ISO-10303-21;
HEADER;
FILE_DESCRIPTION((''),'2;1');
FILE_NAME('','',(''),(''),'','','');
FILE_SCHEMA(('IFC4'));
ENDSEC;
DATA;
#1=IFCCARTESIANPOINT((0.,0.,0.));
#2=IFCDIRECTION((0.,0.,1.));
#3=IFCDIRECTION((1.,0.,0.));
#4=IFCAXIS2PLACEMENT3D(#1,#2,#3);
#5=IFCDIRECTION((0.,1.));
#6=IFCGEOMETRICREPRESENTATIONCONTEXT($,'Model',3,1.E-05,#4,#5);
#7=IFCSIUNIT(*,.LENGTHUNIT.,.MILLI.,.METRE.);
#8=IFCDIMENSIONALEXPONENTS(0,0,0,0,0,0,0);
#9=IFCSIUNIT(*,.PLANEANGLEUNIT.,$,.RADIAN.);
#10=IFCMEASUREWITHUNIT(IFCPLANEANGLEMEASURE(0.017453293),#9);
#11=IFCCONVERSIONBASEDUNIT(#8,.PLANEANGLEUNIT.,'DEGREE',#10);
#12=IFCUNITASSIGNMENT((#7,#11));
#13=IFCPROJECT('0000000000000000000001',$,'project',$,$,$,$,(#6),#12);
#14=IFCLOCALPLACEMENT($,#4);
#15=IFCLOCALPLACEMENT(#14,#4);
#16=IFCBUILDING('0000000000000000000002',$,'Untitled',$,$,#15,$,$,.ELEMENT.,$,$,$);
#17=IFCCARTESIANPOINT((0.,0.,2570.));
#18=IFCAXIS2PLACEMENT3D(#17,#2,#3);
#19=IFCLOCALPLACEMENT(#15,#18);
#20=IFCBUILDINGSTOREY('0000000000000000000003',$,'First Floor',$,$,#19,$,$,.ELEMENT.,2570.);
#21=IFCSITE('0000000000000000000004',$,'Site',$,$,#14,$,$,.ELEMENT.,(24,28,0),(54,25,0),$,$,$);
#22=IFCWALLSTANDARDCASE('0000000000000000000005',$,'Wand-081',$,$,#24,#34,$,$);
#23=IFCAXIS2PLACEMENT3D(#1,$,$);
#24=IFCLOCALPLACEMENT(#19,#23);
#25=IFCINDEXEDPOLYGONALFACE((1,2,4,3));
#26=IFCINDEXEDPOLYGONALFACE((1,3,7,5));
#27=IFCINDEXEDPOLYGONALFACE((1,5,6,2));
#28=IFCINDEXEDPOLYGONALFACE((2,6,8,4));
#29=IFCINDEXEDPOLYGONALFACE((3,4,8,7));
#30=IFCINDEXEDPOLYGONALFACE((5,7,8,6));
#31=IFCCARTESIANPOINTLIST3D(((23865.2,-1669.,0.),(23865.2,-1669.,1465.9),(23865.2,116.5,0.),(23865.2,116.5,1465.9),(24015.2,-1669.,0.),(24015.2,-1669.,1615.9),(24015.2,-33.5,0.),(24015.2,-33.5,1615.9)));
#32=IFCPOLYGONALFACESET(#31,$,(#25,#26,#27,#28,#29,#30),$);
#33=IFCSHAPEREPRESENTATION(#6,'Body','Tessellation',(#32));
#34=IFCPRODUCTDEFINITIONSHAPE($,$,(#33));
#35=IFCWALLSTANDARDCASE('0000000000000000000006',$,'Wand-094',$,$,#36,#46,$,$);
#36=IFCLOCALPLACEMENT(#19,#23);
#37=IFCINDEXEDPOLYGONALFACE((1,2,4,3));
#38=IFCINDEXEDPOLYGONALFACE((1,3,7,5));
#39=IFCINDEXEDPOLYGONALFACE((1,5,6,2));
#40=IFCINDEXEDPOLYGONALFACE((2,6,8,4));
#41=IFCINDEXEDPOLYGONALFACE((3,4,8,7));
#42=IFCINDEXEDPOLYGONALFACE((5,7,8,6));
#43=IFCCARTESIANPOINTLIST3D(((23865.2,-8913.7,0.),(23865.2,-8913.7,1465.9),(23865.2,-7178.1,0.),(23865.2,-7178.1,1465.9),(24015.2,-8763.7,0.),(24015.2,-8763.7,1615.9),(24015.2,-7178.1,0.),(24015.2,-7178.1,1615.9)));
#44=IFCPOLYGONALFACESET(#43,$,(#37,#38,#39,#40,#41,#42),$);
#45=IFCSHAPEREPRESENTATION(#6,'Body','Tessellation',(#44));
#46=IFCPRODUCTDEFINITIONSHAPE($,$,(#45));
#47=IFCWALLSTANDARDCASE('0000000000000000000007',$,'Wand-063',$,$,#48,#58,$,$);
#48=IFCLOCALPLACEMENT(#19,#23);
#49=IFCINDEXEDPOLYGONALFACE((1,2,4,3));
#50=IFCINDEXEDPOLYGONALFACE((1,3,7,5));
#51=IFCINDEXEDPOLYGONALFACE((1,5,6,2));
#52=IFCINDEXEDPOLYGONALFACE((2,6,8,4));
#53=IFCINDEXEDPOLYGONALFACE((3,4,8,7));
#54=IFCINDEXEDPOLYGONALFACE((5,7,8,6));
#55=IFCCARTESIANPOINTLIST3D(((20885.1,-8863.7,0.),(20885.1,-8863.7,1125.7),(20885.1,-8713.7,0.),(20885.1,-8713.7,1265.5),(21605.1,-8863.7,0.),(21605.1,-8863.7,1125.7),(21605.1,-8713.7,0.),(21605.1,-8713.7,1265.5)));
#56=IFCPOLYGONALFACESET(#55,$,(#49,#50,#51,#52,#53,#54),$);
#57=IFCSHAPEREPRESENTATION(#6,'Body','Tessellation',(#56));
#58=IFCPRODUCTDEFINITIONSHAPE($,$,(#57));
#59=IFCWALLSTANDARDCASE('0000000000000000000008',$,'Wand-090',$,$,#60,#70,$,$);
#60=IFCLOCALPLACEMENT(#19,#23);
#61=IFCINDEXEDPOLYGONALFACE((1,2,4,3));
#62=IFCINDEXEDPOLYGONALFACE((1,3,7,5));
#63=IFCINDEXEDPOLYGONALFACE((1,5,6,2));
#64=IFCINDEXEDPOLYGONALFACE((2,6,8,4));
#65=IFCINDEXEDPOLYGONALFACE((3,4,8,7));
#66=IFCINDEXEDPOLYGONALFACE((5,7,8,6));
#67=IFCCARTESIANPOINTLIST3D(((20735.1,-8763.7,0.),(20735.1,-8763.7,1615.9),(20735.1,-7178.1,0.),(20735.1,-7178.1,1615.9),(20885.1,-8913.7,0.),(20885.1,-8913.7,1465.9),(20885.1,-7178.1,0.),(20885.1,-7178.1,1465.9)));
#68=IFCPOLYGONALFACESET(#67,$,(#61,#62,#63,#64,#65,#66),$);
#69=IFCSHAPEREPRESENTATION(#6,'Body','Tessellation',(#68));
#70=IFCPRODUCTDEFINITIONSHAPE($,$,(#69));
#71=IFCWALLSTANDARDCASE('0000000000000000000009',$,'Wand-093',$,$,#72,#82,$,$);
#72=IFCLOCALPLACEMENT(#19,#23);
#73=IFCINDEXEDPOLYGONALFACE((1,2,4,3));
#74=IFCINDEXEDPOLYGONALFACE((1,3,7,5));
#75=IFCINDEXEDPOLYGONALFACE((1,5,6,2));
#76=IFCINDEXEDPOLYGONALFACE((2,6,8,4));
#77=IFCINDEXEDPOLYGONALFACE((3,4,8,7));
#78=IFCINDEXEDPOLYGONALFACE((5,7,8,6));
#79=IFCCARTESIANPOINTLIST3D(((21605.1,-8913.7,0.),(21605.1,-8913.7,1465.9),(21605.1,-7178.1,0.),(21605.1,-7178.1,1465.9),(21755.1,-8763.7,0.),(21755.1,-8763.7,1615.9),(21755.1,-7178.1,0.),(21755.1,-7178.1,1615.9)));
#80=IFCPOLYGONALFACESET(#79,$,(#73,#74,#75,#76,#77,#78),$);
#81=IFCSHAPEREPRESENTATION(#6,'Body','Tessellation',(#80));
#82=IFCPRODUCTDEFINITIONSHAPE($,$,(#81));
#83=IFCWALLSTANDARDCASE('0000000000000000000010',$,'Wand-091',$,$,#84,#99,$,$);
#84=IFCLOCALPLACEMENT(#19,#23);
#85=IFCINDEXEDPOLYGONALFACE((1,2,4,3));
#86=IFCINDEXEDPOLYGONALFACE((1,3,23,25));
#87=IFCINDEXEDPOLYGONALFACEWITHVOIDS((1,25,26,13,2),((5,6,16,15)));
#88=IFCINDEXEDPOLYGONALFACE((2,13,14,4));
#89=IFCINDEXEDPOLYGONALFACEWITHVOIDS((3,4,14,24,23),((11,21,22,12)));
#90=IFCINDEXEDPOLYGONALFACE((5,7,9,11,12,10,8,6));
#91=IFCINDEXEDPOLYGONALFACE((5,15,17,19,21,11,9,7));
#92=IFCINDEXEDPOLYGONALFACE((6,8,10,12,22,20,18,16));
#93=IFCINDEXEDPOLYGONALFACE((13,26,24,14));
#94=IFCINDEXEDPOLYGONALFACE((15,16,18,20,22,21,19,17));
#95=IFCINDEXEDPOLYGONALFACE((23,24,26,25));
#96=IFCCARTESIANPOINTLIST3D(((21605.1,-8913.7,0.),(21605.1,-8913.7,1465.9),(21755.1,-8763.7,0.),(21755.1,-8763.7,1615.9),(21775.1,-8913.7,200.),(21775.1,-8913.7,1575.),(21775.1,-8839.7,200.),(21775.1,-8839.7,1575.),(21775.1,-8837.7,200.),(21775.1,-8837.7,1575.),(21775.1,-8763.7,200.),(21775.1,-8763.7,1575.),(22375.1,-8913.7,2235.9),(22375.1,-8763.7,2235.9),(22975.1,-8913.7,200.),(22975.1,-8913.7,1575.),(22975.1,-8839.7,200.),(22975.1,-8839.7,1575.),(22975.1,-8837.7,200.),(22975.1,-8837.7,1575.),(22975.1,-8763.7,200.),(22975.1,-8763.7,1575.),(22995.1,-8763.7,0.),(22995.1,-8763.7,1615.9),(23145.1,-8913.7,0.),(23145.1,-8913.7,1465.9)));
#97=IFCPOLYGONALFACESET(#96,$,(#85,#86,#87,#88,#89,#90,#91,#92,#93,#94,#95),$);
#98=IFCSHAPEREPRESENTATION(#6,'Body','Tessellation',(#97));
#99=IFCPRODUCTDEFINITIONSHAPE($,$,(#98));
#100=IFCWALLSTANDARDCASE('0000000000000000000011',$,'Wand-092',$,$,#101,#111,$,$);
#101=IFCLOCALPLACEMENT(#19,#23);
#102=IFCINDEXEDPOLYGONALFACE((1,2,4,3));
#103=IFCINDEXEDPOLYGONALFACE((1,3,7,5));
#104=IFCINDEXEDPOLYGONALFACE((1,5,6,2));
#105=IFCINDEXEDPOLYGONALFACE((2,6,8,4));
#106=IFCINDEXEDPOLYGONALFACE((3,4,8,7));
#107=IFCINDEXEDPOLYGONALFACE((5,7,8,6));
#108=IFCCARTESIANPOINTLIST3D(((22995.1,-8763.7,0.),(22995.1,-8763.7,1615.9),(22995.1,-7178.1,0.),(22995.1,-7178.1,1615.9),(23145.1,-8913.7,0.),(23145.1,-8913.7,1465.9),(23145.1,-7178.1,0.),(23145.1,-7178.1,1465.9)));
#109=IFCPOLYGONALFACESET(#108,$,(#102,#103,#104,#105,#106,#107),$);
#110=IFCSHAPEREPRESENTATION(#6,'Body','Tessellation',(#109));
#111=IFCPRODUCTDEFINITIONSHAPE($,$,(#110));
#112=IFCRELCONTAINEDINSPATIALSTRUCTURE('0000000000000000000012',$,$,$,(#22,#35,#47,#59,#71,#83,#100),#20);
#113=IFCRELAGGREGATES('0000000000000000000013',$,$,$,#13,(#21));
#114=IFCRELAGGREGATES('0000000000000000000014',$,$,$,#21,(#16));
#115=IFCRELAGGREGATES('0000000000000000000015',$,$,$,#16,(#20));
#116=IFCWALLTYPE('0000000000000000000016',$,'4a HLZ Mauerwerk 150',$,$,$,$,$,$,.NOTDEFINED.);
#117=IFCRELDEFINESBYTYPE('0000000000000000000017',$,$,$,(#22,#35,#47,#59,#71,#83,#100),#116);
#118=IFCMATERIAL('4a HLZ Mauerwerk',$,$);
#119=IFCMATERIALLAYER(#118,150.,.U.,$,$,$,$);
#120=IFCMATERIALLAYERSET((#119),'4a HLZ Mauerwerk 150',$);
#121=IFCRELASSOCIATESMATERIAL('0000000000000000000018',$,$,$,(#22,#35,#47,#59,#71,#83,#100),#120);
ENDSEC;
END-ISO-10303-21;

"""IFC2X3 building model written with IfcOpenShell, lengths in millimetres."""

from ifc_helpers import new_model, entity, si_unit, converted_unit, direction, frame, origin_with_axes, origin_2d_with_axis, place, context, project, spatial, polyline, rectangle, outline, extrude, clip, halfspace, bounded_halfspace, material, layer, layer_set, layer_usage, type_object, element, save


model = new_model("IFC2X3")

# Units and contexts
model_context = context("Model", 3, precision=1e-05, world=origin_with_axes(), true_north=direction((0.0, 1.0)))
ifc_project = project(units=[si_unit("LENGTHUNIT", "METRE", prefix="MILLI"), converted_unit("PLANEANGLEUNIT", "DEGREE", entity("IfcPlaneAngleMeasure", 0.017453293), si_unit("PLANEANGLEUNIT", "RADIAN"), dimensions=[0, 0, 0, 0, 0, 0, 0])], contexts=[model_context])

# Site, building, storey
site_placement = place(None, origin_with_axes())
site = spatial("IfcSite", under=ifc_project, at=site_placement, Name="Site", CompositionType="ELEMENT", RefLatitude=(24, 28, 0), RefLongitude=(54, 25, 0))
building_placement = place(site_placement, origin_with_axes())
building = spatial("IfcBuilding", under=site, at=building_placement, Name="Untitled", CompositionType="ELEMENT")
storey_placement = place(building_placement, frame((0.0, 0.0, 2570.0), z_axis=(0.0, 0.0, 1.0), x_axis=(1.0, 0.0, 0.0)))
storey = spatial("IfcBuildingStorey", under=building, at=storey_placement, Name="First Floor", CompositionType="ELEMENT", Elevation=2570.0)

# Shared definitions
ifc_material = material(Name="4a HLZ Mauerwerk")
ifc_layer_1 = layer(ifc_material, 150.0, ventilated="UNKNOWN")
ifc_layer_set_1 = layer_set([ifc_layer_1], Name="4a HLZ Mauerwerk 150")
wall_type_1 = type_object("IfcWallType", Name="4a HLZ Mauerwerk 150", PredefinedType="NOTDEFINED")

# Walls
ifc_layer_usage_1 = layer_usage(ifc_layer_set_1, "AXIS2", "POSITIVE", 0.0)
wall_1_placement = place(storey_placement, frame((23865.2, 116.5, 0.0), z_axis=(0.0, 0.0, 1.0), x_axis=(0.0, -1.0, 0.0)))
element("IfcWallStandardCase", 1, at=wall_1_placement, inside=storey, type_object=wall_type_1, material=ifc_layer_usage_1, Name="Wand-081", context=model_context, shape_type="Clipping", body=[
    clip(extrude(outline(polyline([(0.0, 0.0), (1785.6, 0.0), (1785.6, 150.0), (150.0, 150.0), (0.0, 0.0)])), origin_with_axes(), (0.0, 0.0, 1.0), 5316.0), halfspace(frame((0.0, -733.0, 733.0), z_axis=(0.0, 0.707107, -0.707107), x_axis=(0.0, -0.707107, -0.707107)), True)),
])
ifc_layer_usage_2 = layer_usage(ifc_layer_set_1, "AXIS2", "NEGATIVE", 0.0)
wall_2_placement = place(storey_placement, frame((23865.2, -8913.7, 0.0), z_axis=(0.0, 0.0, 1.0), x_axis=(0.0, 1.0, 0.0)))
element("IfcWallStandardCase", 2, at=wall_2_placement, inside=storey, type_object=wall_type_1, material=ifc_layer_usage_2, Name="Wand-094", context=model_context, shape_type="Clipping", body=[
    clip(extrude(outline(polyline([(150.0, -150.0), (1735.6, -150.0), (1735.6, 0.0), (0.0, 0.0), (150.0, -150.0)])), origin_with_axes(), (0.0, 0.0, 1.0), 5316.0), halfspace(frame((0.0, 733.0, 733.0), z_axis=(0.0, -0.707107, -0.707107), x_axis=(0.0, -0.707107, 0.707107)), True)),
])
ifc_layer_usage_3 = layer_usage(ifc_layer_set_1, "AXIS2", "POSITIVE", 0.0)
wall_3_placement = place(storey_placement, frame((20885.1, -8863.7, 0.0), z_axis=(0.0, 0.0, 1.0), x_axis=(1.0, 0.0, 0.0)))
element("IfcWallStandardCase", 3, at=wall_3_placement, inside=storey, type_object=wall_type_1, material=ifc_layer_usage_3, Name="Wand-063", context=model_context, shape_type="Clipping", body=[
    clip(extrude(outline(polyline([(0.0, 0.0), (720.0, 0.0), (720.0, 150.0), (0.0, 150.0), (0.0, 0.0)])), origin_with_axes(), (0.0, 0.0, 1.0), 5316.0), bounded_halfspace(frame((0.0, -561.5, 602.1), z_axis=(0.0, 0.681998, -0.731354), x_axis=(0.0, -0.731354, -0.681998)), True, origin_with_axes(), polyline([(0.0, 0.0), (720.0, 0.0), (720.0, 150.0), (0.0, 150.0), (0.0, 0.0)]))),
])
ifc_layer_usage_4 = layer_usage(ifc_layer_set_1, "AXIS2", "POSITIVE", 0.0)
wall_4_placement = place(storey_placement, frame((20885.1, -8913.7, 0.0), z_axis=(0.0, 0.0, 1.0), x_axis=(0.0, 1.0, 0.0)))
element("IfcWallStandardCase", 4, at=wall_4_placement, inside=storey, type_object=wall_type_1, material=ifc_layer_usage_4, Name="Wand-090", context=model_context, shape_type="Clipping", body=[
    clip(extrude(outline(polyline([(0.0, 0.0), (1735.6, 0.0), (1735.6, 150.0), (150.0, 150.0), (0.0, 0.0)])), origin_with_axes(), (0.0, 0.0, 1.0), 5316.0), halfspace(frame((0.0, -733.0, 733.0), z_axis=(0.0, 0.707107, -0.707107), x_axis=(0.0, -0.707107, -0.707107)), True)),
])
ifc_layer_usage_5 = layer_usage(ifc_layer_set_1, "AXIS2", "NEGATIVE", 0.0)
wall_5_placement = place(storey_placement, frame((21605.1, -8913.7, 0.0), z_axis=(0.0, 0.0, 1.0), x_axis=(0.0, 1.0, 0.0)))
element("IfcWallStandardCase", 5, at=wall_5_placement, inside=storey, type_object=wall_type_1, material=ifc_layer_usage_5, Name="Wand-093", context=model_context, shape_type="Clipping", body=[
    clip(extrude(outline(polyline([(150.0, -150.0), (1735.6, -150.0), (1735.6, 0.0), (0.0, 0.0), (150.0, -150.0)])), origin_with_axes(), (0.0, 0.0, 1.0), 5316.0), halfspace(frame((0.0, 733.0, 733.0), z_axis=(0.0, -0.707107, -0.707107), x_axis=(0.0, -0.707107, 0.707107)), True)),
])

# Wall, opening
ifc_layer_usage_6 = layer_usage(ifc_layer_set_1, "AXIS2", "POSITIVE", 0.0)
wall_6_placement = place(storey_placement, frame((21605.1, -8913.7, 0.0), z_axis=(0.0, 0.0, 1.0), x_axis=(1.0, 0.0, 0.0)))
wall_6 = element("IfcWallStandardCase", 6, at=wall_6_placement, inside=storey, type_object=wall_type_1, material=ifc_layer_usage_6, Name="Wand-091", context=model_context, shape_type="Clipping", body=[
    clip(clip(extrude(outline(polyline([(0.0, 0.0), (1540.0, 0.0), (1390.0, 150.0), (150.0, 150.0), (0.0, 0.0)])), origin_with_axes(), (0.0, 0.0, 1.0), 5316.0), bounded_halfspace(frame((1503.0, 0.0, 1503.0), z_axis=(-0.707107, 0.0, -0.707107), x_axis=(0.707107, 0.0, -0.707107)), True, origin_with_axes(), polyline([(770.0, 0.0), (1540.0, 0.0), (1540.0, 150.0), (770.0, 150.0), (770.0, 0.0)]))), bounded_halfspace(frame((-733.0, 0.0, 733.0), z_axis=(0.707107, 0.0, -0.707107), x_axis=(0.707107, 0.0, 0.707107)), True, origin_with_axes(), polyline([(0.0, 0.0), (770.0, 0.0), (770.0, 150.0), (0.0, 150.0), (0.0, 0.0)]))),
])
opening_1_placement = place(wall_6_placement, frame((770.0, 0.0, 200.0), z_axis=(0.0, 0.0, 1.0), x_axis=(1.0, 0.0, 0.0)))
element("IfcOpeningElement", 7, at=opening_1_placement, cuts=wall_6, context=model_context, shape_type="SweptSolid", body=[
    extrude(rectangle(XDim=1200.0, YDim=1375.0, at=origin_2d_with_axis()), frame((0.0, -226.0, 687.5), z_axis=(0.0, 1.0, 0.0), x_axis=(1.0, 0.0, 0.0)), (0.0, 0.0, 1.0), 302.0),
    extrude(rectangle(XDim=1200.0, YDim=1375.0, at=origin_2d_with_axis()), frame((0.0, 376.0, 687.5), z_axis=(0.0, -1.0, 0.0), x_axis=(1.0, 0.0, 0.0)), (0.0, 0.0, 1.0), 302.0),
])

# Wall
ifc_layer_usage_7 = layer_usage(ifc_layer_set_1, "AXIS2", "POSITIVE", 0.0)
wall_7_placement = place(storey_placement, frame((23145.1, -8913.7, 0.0), z_axis=(0.0, 0.0, 1.0), x_axis=(0.0, 1.0, 0.0)))
element("IfcWallStandardCase", 8, at=wall_7_placement, inside=storey, type_object=wall_type_1, material=ifc_layer_usage_7, Name="Wand-092", context=model_context, shape_type="Clipping", body=[
    clip(extrude(outline(polyline([(0.0, 0.0), (1735.6, 0.0), (1735.6, 150.0), (150.0, 150.0), (0.0, 0.0)])), origin_with_axes(), (0.0, 0.0, 1.0), 5316.0), halfspace(frame((0.0, -733.0, 733.0), z_axis=(0.0, 0.707107, -0.707107), x_axis=(0.0, -0.707107, -0.707107)), True)),
])

save(model, "model.ifc")
